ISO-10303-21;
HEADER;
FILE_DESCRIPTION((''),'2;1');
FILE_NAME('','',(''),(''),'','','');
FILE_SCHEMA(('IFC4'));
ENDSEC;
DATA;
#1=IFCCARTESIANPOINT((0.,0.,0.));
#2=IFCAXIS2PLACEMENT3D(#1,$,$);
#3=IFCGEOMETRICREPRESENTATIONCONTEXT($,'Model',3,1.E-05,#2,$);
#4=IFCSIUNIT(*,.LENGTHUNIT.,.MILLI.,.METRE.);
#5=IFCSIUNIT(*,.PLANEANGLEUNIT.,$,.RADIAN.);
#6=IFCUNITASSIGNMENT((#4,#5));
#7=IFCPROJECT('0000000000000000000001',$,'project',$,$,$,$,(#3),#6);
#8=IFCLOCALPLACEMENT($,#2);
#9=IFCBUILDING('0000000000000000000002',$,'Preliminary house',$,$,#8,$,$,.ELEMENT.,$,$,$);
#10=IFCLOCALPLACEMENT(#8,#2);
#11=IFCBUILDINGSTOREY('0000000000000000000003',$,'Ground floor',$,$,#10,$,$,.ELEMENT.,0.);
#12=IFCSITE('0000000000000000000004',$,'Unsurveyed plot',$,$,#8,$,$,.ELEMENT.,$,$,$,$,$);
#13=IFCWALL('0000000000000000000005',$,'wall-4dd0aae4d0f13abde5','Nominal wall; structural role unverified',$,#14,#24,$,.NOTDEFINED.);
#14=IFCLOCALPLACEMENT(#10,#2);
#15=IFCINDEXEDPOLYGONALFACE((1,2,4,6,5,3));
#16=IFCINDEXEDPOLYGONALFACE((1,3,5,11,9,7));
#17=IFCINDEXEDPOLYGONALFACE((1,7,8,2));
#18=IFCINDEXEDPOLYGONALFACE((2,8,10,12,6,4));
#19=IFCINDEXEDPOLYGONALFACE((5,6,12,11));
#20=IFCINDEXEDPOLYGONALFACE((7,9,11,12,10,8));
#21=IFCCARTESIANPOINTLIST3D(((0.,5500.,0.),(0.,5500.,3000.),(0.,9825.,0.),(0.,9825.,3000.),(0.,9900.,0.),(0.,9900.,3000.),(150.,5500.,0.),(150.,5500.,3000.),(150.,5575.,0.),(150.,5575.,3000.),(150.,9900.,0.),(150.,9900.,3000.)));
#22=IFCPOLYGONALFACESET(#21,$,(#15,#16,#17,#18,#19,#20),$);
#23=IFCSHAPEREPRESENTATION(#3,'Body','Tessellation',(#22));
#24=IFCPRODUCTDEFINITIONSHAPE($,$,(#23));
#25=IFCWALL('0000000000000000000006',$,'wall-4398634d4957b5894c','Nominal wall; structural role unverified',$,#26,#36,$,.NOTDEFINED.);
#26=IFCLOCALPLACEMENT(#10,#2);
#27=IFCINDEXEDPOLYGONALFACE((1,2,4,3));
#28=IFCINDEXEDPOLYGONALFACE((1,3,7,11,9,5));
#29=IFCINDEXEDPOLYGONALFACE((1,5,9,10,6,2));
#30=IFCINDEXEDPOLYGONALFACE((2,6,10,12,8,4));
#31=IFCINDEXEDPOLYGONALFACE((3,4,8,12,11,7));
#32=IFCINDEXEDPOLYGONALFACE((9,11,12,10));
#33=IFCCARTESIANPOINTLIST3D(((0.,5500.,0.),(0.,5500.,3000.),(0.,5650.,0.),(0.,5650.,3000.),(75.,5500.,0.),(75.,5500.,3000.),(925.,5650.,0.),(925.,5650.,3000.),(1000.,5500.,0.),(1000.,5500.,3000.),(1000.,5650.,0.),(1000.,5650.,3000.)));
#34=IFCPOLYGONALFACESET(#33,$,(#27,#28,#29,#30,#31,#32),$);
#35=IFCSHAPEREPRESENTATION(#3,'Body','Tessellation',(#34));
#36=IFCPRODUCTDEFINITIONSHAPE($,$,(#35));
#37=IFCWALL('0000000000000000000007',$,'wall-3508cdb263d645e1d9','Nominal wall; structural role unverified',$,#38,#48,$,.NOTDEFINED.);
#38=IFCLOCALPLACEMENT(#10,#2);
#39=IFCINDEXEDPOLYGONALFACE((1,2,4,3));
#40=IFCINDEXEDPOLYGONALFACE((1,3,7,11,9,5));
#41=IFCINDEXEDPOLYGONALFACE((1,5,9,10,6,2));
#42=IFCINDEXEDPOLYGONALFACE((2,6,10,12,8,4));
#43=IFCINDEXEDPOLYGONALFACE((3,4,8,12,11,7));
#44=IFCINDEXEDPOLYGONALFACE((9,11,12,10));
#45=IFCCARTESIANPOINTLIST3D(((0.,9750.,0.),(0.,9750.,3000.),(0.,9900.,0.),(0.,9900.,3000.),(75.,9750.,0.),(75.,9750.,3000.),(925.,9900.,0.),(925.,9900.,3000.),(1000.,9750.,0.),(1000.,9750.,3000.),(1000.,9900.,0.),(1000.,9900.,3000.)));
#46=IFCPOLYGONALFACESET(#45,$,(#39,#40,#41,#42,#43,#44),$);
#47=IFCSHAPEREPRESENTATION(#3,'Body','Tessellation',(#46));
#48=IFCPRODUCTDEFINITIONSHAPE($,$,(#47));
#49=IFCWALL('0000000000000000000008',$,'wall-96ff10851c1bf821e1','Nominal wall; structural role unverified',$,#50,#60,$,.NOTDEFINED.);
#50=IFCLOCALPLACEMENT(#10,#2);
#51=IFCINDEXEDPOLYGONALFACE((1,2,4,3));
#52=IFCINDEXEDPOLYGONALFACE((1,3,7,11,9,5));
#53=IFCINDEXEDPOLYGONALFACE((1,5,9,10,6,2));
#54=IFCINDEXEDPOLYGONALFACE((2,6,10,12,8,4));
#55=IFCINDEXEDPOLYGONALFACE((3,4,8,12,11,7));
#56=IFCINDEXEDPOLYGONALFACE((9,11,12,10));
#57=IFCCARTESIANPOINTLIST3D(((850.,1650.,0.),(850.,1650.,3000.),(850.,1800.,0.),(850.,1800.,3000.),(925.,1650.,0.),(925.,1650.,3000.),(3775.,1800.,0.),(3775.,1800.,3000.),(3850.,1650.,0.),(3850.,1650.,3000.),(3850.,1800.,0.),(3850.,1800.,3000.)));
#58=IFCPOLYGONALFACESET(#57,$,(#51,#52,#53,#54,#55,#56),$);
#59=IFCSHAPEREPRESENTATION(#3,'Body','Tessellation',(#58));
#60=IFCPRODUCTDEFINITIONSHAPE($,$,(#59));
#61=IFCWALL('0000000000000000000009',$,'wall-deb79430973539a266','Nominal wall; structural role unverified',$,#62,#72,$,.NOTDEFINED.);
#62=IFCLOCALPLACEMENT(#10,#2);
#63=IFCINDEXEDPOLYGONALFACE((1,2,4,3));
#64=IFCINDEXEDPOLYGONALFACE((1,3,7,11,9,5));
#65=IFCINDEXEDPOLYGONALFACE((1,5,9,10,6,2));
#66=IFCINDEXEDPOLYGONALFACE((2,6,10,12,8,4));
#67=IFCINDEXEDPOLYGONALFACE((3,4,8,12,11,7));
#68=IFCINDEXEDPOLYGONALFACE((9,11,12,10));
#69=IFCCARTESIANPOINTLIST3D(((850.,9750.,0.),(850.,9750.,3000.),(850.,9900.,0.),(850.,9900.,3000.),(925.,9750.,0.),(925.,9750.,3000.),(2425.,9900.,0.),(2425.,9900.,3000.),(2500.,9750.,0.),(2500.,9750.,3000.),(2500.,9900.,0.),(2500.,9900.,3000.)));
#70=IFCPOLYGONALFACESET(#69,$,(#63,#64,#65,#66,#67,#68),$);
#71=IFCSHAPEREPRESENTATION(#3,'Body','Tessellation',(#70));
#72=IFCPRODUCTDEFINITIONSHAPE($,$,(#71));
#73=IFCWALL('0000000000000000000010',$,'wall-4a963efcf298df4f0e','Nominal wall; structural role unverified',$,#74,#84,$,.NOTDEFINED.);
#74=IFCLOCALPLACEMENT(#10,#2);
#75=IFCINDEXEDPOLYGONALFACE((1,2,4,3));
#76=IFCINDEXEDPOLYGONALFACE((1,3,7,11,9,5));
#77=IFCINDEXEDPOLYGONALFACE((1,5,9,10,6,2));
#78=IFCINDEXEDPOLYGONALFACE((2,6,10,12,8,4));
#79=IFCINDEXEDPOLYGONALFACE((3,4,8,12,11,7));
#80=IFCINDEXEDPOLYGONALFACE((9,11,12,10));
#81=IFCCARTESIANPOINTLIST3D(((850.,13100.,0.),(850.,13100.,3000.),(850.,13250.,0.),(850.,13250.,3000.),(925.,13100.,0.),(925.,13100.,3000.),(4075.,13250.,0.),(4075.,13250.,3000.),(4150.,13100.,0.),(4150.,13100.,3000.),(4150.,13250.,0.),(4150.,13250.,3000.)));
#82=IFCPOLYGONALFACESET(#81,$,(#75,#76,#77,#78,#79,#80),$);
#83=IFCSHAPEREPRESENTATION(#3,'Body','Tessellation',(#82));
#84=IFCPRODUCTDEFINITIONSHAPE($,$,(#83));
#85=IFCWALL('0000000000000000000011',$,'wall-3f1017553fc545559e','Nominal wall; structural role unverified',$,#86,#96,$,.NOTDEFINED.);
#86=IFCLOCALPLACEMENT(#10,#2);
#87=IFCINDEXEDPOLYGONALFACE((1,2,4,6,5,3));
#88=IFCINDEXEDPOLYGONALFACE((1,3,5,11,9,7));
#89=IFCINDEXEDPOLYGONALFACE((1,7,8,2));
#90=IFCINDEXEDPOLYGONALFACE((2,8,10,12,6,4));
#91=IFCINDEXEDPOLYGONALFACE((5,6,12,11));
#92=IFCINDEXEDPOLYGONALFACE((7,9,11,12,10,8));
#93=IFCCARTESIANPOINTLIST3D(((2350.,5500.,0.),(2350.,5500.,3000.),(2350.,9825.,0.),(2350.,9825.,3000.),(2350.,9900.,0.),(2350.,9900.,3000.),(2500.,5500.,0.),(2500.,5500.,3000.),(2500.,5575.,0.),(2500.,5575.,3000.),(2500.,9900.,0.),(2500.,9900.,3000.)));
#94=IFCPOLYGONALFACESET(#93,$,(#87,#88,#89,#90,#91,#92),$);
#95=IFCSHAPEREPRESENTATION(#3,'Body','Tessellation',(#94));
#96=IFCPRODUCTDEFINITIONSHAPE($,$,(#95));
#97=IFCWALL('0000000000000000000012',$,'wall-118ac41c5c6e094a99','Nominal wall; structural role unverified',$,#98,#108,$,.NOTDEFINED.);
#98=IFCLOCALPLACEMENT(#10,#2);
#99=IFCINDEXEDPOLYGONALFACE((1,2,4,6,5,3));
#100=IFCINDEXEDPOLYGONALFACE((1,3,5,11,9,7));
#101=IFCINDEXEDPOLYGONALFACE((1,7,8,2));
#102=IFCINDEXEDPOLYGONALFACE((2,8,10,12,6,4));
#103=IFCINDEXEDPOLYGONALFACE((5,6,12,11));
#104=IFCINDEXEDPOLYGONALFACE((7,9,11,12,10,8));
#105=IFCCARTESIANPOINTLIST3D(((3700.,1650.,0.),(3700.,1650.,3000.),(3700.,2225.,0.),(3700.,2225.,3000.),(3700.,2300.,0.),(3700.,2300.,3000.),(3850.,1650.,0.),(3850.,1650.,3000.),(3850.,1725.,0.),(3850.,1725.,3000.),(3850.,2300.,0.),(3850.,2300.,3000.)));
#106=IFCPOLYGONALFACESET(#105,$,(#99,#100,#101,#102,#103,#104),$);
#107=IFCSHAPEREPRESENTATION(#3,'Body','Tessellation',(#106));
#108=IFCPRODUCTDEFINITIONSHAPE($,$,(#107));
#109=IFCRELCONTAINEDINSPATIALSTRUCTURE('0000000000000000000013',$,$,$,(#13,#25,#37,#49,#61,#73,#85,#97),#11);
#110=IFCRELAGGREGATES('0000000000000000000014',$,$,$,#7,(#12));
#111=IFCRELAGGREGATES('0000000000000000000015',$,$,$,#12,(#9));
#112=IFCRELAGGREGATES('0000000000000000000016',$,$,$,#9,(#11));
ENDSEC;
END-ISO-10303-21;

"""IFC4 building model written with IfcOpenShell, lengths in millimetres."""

from ifc_helpers import new_model, si_unit, origin, place, context, project, spatial, polyline, outline, extrude, element, save


model = new_model("IFC4")

# Units and contexts
model_context = context("Model", 3, precision=1e-05, world=origin())
ifc_project = project(units=[si_unit("LENGTHUNIT", "METRE", prefix="MILLI"), si_unit("PLANEANGLEUNIT", "RADIAN")], contexts=[model_context])

# Site, building, storey
placement_1 = place(None, origin())
site = spatial("IfcSite", under=ifc_project, at=placement_1, Name="Unsurveyed plot", CompositionType="ELEMENT")
building = spatial("IfcBuilding", under=site, at=placement_1, Name="Preliminary house", CompositionType="ELEMENT")
placement_2 = place(placement_1, origin())
storey = spatial("IfcBuildingStorey", under=building, at=placement_2, Name="Ground floor", CompositionType="ELEMENT", Elevation=0.0)

# Walls
element("IfcWall", 1, at=placement_2, inside=storey, Name="wall-4dd0aae4d0f13abde5", Description="Nominal wall; structural role unverified", PredefinedType="NOTDEFINED", context=model_context, shape_type="SweptSolid", body=[
    extrude(outline(polyline([(0.0, 9825.0), (0.0, 9900.0), (150.0, 9900.0), (150.0, 5575.0), (150.0, 5500.0), (0.0, 5500.0), (0.0, 9825.0)])), origin(), (0.0, 0.0, 1.0), 3000.0),
])
element("IfcWall", 2, at=placement_2, inside=storey, Name="wall-4398634d4957b5894c", Description="Nominal wall; structural role unverified", PredefinedType="NOTDEFINED", context=model_context, shape_type="SweptSolid", body=[
    extrude(outline(polyline([(925.0, 5650.0), (1000.0, 5650.0), (1000.0, 5500.0), (75.0, 5500.0), (0.0, 5500.0), (0.0, 5650.0), (925.0, 5650.0)])), origin(), (0.0, 0.0, 1.0), 3000.0),
])
element("IfcWall", 3, at=placement_2, inside=storey, Name="wall-3508cdb263d645e1d9", Description="Nominal wall; structural role unverified", PredefinedType="NOTDEFINED", context=model_context, shape_type="SweptSolid", body=[
    extrude(outline(polyline([(925.0, 9900.0), (1000.0, 9900.0), (1000.0, 9750.0), (75.0, 9750.0), (0.0, 9750.0), (0.0, 9900.0), (925.0, 9900.0)])), origin(), (0.0, 0.0, 1.0), 3000.0),
])

# Wall
element("IfcWall", 4, at=placement_2, inside=storey, Name="wall-96ff10851c1bf821e1", Description="Nominal wall; structural role unverified", PredefinedType="NOTDEFINED", context=model_context, shape_type="SweptSolid", body=[
    extrude(outline(polyline([(3775.0, 1800.0), (3850.0, 1800.0), (3850.0, 1650.0), (925.0, 1650.0), (850.0, 1650.0), (850.0, 1800.0), (3775.0, 1800.0)])), origin(), (0.0, 0.0, 1.0), 3000.0),
])

# Walls
element("IfcWall", 5, at=placement_2, inside=storey, Name="wall-deb79430973539a266", Description="Nominal wall; structural role unverified", PredefinedType="NOTDEFINED", context=model_context, shape_type="SweptSolid", body=[
    extrude(outline(polyline([(2425.0, 9900.0), (2500.0, 9900.0), (2500.0, 9750.0), (925.0, 9750.0), (850.0, 9750.0), (850.0, 9900.0), (2425.0, 9900.0)])), origin(), (0.0, 0.0, 1.0), 3000.0),
])
element("IfcWall", 6, at=placement_2, inside=storey, Name="wall-4a963efcf298df4f0e", Description="Nominal wall; structural role unverified", PredefinedType="NOTDEFINED", context=model_context, shape_type="SweptSolid", body=[
    extrude(outline(polyline([(4075.0, 13250.0), (4150.0, 13250.0), (4150.0, 13100.0), (925.0, 13100.0), (850.0, 13100.0), (850.0, 13250.0), (4075.0, 13250.0)])), origin(), (0.0, 0.0, 1.0), 3000.0),
])
element("IfcWall", 7, at=placement_2, inside=storey, Name="wall-3f1017553fc545559e", Description="Nominal wall; structural role unverified", PredefinedType="NOTDEFINED", context=model_context, shape_type="SweptSolid", body=[
    extrude(outline(polyline([(2350.0, 9825.0), (2350.0, 9900.0), (2500.0, 9900.0), (2500.0, 5575.0), (2500.0, 5500.0), (2350.0, 5500.0), (2350.0, 9825.0)])), origin(), (0.0, 0.0, 1.0), 3000.0),
])

# Wall
element("IfcWall", 8, at=placement_2, inside=storey, Name="wall-118ac41c5c6e094a99", Description="Nominal wall; structural role unverified", PredefinedType="NOTDEFINED", context=model_context, shape_type="SweptSolid", body=[
    extrude(outline(polyline([(3700.0, 2225.0), (3700.0, 2300.0), (3850.0, 2300.0), (3850.0, 1725.0), (3850.0, 1650.0), (3700.0, 1650.0), (3700.0, 2225.0)])), origin(), (0.0, 0.0, 1.0), 3000.0),
])

save(model, "model.ifc")
